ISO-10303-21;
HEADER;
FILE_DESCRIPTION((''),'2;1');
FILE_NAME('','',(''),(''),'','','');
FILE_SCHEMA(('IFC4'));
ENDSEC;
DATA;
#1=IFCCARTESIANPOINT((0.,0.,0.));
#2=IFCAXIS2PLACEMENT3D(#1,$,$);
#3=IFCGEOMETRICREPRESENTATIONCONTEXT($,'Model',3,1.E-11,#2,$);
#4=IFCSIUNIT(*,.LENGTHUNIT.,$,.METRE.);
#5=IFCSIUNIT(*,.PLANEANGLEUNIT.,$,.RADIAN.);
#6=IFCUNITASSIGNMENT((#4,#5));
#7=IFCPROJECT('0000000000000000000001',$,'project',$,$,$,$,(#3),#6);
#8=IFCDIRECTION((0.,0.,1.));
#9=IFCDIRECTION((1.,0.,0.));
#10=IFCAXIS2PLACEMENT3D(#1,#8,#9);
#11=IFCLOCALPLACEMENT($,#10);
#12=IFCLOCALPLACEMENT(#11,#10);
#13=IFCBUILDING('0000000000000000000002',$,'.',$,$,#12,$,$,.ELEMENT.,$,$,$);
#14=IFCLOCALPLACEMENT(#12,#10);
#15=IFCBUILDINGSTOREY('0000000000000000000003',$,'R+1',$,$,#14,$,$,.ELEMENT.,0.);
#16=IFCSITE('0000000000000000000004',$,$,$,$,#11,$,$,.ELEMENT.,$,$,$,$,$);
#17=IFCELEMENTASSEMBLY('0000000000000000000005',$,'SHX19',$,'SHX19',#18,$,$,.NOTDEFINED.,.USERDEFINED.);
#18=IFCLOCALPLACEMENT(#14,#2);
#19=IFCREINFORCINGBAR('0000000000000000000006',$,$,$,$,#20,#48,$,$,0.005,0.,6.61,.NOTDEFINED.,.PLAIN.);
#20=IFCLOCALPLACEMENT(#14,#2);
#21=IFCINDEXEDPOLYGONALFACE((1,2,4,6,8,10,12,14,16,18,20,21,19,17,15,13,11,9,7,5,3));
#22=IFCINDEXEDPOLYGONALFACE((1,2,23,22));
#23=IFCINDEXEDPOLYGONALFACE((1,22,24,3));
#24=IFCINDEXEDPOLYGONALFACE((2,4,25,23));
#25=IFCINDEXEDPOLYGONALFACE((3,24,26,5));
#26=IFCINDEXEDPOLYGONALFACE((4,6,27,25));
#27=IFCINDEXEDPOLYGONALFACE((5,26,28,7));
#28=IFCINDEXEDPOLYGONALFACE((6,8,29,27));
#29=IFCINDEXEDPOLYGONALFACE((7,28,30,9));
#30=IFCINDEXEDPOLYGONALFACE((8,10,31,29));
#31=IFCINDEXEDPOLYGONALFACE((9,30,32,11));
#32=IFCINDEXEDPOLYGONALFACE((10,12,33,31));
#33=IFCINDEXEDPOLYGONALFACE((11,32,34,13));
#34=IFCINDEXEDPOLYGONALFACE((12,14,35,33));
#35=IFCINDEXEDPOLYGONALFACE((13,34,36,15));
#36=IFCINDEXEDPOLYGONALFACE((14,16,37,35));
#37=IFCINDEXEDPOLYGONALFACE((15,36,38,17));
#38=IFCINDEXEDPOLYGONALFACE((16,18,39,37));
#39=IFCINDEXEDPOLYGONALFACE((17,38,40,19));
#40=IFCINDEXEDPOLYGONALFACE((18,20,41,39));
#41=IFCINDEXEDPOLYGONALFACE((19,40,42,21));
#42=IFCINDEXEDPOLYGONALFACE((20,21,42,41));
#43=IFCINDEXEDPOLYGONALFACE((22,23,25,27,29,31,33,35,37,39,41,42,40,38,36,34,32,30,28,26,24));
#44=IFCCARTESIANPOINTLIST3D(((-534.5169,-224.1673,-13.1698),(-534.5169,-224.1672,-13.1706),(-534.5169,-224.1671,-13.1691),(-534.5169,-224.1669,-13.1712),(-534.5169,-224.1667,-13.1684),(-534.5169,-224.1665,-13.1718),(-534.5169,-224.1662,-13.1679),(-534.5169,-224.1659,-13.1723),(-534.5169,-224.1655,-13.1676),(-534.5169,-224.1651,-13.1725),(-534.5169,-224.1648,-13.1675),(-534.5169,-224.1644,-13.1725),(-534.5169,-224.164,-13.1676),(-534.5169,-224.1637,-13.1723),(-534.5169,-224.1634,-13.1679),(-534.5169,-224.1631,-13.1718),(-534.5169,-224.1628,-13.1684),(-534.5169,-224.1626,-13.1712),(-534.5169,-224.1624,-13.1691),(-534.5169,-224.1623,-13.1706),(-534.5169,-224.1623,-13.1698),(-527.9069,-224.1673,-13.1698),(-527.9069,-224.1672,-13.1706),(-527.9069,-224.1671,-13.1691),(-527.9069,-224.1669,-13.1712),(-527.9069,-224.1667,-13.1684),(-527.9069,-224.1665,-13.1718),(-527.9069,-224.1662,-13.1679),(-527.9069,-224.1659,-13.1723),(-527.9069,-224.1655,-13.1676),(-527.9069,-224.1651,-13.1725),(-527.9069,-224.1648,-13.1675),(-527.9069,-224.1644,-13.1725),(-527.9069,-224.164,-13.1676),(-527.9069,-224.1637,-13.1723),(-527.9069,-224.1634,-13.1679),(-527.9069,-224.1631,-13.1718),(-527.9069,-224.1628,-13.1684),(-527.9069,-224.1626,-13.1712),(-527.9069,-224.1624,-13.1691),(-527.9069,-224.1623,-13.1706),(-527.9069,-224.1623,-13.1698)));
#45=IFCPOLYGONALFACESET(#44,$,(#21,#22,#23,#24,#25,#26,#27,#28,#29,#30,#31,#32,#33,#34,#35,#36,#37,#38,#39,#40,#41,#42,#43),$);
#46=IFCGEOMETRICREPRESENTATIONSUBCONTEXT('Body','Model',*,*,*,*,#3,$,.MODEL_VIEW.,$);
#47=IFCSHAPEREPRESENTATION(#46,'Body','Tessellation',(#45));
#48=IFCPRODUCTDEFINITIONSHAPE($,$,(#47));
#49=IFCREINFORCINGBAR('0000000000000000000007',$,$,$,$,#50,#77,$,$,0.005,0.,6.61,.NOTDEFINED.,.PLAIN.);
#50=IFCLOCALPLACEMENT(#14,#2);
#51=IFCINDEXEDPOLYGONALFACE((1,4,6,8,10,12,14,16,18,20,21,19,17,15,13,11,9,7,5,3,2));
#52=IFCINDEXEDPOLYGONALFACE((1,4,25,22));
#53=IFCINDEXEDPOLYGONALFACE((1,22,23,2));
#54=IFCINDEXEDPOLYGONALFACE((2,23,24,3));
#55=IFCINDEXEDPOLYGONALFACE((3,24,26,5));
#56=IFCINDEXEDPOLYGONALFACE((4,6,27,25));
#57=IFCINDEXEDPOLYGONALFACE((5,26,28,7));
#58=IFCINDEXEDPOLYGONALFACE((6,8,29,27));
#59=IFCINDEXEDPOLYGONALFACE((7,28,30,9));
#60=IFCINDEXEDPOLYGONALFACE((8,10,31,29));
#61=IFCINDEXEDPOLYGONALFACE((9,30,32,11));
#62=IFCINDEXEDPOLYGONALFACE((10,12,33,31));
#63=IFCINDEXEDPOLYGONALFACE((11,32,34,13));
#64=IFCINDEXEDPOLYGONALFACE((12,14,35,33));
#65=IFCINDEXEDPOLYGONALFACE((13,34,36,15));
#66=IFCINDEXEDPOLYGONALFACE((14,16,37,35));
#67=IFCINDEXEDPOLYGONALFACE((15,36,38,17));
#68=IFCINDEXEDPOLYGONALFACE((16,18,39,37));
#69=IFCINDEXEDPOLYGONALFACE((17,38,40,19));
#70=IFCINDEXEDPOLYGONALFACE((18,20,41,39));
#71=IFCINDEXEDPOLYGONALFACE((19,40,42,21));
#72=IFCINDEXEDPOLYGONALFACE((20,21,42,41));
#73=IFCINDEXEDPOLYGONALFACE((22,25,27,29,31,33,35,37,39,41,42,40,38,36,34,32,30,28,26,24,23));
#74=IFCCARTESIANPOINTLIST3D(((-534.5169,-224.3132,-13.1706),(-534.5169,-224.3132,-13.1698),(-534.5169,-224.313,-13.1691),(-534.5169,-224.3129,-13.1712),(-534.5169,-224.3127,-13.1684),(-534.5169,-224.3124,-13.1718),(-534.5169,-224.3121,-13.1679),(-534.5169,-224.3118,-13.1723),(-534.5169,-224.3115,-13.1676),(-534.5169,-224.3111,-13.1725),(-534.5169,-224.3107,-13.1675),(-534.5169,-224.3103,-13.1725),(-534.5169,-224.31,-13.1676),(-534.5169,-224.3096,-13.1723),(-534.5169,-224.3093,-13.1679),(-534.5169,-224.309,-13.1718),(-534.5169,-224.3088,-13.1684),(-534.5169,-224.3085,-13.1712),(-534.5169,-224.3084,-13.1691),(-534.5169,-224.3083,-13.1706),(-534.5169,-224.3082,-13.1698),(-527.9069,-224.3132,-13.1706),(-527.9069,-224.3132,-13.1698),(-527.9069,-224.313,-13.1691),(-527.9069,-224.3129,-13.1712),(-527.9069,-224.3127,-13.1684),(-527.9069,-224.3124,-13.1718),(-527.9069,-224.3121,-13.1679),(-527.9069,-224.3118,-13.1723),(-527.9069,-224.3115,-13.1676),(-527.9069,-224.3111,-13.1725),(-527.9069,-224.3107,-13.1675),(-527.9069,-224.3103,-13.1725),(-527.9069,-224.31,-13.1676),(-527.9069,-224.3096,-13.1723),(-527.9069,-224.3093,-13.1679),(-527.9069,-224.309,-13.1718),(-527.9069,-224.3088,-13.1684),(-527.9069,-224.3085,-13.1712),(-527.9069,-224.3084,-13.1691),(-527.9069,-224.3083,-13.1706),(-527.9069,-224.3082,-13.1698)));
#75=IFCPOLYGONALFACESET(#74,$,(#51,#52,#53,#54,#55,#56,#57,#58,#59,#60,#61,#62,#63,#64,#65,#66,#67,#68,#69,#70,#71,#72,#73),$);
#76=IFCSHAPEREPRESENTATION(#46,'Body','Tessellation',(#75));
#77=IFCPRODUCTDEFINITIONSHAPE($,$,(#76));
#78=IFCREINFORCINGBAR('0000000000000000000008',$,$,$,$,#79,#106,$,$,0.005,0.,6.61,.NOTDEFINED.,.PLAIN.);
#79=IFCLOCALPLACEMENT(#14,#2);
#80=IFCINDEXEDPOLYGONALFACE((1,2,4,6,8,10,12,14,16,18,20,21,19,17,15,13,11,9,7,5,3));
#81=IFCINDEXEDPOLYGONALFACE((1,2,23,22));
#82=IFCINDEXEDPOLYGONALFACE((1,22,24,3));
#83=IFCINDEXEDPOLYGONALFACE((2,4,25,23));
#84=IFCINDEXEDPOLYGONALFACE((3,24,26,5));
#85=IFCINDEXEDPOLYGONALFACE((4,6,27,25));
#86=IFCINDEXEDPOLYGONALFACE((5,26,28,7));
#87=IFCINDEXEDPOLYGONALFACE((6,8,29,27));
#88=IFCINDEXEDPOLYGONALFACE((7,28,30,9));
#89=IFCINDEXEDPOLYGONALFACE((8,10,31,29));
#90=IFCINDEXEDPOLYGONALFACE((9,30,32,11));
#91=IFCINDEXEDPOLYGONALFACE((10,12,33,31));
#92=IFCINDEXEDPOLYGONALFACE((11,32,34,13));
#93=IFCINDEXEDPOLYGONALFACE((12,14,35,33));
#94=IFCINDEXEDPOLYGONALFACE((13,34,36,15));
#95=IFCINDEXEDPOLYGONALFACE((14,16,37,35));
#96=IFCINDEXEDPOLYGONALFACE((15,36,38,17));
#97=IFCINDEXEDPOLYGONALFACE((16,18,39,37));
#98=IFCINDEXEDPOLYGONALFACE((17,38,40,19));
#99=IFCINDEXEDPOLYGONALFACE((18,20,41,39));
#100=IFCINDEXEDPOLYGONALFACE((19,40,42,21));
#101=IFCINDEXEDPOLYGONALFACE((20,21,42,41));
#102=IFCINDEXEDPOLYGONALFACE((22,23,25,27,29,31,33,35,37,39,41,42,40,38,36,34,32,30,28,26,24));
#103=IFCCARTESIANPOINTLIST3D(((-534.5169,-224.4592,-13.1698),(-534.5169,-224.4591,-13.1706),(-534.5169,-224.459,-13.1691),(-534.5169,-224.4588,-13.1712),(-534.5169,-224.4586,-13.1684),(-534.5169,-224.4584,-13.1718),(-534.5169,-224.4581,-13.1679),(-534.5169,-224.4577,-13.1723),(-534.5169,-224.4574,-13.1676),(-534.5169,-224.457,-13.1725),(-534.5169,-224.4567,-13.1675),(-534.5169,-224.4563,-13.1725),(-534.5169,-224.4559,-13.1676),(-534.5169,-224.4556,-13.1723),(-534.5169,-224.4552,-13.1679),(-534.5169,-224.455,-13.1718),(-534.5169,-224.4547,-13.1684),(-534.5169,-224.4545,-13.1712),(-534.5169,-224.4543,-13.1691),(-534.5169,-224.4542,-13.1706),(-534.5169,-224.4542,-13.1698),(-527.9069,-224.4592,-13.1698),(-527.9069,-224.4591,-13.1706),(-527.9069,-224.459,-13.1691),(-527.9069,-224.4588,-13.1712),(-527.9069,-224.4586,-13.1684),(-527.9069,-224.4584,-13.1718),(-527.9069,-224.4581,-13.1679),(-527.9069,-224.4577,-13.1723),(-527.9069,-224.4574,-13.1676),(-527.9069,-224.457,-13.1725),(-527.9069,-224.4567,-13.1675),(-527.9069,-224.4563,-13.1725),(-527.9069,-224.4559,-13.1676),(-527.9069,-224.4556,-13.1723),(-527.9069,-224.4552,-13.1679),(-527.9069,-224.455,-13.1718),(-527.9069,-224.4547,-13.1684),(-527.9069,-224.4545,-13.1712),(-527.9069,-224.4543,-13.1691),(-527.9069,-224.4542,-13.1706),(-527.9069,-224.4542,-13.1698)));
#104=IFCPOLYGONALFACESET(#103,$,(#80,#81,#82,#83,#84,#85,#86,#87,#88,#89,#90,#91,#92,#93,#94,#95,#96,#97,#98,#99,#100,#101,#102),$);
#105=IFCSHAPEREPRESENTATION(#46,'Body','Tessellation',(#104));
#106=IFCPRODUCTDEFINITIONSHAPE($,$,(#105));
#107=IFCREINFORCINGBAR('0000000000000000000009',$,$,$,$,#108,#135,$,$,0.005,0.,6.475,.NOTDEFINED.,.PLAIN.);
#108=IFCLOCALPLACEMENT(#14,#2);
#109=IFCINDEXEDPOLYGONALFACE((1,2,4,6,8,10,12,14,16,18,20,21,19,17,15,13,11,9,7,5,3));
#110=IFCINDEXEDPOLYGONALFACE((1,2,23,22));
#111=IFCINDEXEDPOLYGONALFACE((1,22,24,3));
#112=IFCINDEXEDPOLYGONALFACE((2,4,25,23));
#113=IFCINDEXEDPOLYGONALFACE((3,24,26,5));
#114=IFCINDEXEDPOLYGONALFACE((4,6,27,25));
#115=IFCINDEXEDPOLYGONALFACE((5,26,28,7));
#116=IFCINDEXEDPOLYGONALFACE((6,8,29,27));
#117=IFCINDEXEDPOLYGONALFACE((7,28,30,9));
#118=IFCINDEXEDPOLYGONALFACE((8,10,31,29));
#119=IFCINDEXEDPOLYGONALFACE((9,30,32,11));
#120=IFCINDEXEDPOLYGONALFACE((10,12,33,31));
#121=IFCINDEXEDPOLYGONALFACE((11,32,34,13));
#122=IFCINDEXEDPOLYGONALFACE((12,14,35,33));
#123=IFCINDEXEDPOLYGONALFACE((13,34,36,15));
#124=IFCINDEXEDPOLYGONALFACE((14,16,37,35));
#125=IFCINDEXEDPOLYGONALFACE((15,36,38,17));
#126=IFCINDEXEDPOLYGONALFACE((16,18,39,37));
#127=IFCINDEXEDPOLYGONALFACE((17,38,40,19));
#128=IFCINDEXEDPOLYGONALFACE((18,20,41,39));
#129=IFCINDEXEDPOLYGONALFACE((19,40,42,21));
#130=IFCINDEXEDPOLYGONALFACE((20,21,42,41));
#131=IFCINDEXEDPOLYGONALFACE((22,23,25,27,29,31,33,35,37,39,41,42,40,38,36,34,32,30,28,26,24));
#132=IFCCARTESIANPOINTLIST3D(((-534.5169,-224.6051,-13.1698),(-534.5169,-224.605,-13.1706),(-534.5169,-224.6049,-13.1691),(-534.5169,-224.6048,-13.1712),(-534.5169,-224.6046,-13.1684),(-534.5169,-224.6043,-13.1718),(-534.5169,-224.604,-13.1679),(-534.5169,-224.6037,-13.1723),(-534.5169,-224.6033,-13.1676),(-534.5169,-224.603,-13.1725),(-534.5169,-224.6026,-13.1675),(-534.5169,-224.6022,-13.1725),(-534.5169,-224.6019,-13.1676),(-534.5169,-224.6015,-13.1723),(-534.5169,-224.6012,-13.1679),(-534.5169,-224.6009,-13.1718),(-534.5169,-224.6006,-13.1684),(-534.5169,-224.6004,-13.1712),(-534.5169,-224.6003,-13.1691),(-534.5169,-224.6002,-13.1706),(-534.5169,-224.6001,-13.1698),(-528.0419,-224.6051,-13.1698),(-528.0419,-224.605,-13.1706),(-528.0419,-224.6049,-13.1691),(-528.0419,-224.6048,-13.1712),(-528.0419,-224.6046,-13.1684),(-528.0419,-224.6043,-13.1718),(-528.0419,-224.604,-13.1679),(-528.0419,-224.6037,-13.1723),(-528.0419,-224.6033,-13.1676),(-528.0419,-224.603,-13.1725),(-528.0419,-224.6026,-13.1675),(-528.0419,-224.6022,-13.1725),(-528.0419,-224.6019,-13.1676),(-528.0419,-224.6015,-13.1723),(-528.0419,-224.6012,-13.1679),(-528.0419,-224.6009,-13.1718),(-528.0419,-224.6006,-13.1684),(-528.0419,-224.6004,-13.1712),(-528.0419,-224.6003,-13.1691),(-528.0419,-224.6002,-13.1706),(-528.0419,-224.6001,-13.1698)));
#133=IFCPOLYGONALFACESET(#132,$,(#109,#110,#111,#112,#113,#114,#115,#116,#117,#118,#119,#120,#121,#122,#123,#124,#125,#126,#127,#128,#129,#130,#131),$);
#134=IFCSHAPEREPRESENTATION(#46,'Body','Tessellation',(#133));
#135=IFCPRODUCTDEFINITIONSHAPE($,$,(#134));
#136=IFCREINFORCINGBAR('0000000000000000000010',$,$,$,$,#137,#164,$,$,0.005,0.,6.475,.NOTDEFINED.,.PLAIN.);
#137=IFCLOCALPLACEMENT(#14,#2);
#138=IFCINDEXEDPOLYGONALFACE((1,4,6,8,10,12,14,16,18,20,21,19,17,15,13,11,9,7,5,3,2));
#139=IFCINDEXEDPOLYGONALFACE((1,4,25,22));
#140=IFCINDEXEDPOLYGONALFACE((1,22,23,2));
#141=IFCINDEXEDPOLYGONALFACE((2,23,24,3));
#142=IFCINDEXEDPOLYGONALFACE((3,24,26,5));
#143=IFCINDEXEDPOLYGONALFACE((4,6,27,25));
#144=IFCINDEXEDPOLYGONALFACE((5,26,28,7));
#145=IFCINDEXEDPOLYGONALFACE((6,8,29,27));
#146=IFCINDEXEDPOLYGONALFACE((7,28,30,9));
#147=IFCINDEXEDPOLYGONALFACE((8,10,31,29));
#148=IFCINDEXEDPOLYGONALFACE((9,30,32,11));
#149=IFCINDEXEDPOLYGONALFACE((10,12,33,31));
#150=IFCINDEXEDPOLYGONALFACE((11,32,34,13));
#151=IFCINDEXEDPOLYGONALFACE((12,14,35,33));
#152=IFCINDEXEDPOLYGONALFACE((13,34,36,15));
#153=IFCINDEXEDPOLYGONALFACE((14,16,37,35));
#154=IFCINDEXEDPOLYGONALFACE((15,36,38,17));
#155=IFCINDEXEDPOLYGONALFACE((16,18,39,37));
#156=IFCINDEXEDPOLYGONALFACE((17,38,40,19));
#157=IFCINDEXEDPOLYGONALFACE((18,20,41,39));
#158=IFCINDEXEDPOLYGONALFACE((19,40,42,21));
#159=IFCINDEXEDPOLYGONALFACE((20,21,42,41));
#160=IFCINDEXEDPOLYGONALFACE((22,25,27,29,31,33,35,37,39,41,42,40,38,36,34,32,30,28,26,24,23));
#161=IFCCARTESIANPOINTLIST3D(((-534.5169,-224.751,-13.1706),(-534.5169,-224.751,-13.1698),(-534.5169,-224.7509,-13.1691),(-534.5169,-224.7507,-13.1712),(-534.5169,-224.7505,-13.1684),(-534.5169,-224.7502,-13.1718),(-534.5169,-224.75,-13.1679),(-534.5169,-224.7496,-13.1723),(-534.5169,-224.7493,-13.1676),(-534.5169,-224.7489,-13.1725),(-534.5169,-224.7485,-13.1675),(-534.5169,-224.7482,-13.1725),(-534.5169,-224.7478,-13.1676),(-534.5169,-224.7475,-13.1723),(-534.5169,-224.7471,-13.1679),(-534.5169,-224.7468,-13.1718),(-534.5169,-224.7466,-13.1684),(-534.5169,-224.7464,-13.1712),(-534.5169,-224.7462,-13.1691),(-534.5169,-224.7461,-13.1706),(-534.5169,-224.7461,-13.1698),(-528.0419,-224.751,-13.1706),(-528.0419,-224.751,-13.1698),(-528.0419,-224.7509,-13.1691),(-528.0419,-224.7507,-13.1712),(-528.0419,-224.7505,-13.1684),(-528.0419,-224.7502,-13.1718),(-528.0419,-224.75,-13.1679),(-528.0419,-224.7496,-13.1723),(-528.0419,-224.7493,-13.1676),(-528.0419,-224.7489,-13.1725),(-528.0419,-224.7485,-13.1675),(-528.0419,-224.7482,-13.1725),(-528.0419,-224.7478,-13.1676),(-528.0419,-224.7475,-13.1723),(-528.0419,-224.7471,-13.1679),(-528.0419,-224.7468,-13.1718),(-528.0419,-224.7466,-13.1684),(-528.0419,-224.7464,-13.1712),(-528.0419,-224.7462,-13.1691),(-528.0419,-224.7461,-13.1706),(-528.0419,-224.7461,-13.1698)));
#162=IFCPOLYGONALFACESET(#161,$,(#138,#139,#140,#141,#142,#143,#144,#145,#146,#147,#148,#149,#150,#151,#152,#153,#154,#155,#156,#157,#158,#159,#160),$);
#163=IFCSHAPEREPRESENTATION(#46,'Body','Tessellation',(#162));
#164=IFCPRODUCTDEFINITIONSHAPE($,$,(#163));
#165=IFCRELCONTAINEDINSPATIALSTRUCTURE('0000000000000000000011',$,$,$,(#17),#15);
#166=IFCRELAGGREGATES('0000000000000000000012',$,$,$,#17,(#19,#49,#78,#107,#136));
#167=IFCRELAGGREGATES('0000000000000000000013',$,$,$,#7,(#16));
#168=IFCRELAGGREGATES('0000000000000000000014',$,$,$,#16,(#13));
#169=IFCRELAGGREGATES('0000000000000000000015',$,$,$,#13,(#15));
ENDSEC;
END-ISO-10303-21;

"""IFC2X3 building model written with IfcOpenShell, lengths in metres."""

from ifc_helpers import new_model, entity, si_unit, origin, origin_with_axes, place, context, subcontext, project, spatial, shape, element, aggregate, save


model = new_model("IFC2X3")

# Units and contexts
model_context = context("Model", 3, precision=1e-11, world=origin())
body_context = subcontext(model_context, "Body", "Model", "MODEL_VIEW")
ifc_project = project(units=[si_unit("LENGTHUNIT", "METRE"), si_unit("PLANEANGLEUNIT", "RADIAN")], contexts=[model_context])

# Site, building, storey
site_placement = place(None, origin_with_axes())
site = spatial("IfcSite", under=ifc_project, at=site_placement, CompositionType="ELEMENT")
building_placement = place(site_placement, origin_with_axes())
building = spatial("IfcBuilding", under=site, at=building_placement, Name=".", CompositionType="ELEMENT")
storey_placement = place(building_placement, origin_with_axes())
storey = spatial("IfcBuildingStorey", under=building, at=storey_placement, Name="R+1", CompositionType="ELEMENT", Elevation=0.0)

# Element assembly, reinforcing bars
assembly_1_placement = place(storey_placement, origin_with_axes())
assembly_1 = element("IfcElementAssembly", 1, at=assembly_1_placement, inside=storey, Name="SHX19", ObjectType="SHX19", AssemblyPlace="NOTDEFINED", PredefinedType="USERDEFINED")
reinforcing_bar_1_placement = place(assembly_1_placement, origin_with_axes())
reinforcing_bar_1 = element("IfcReinforcingBar", 2, at=reinforcing_bar_1_placement, BarLength=6.61, BarRole="NOTDEFINED", BarSurface="PLAIN", CrossSectionArea=0.0, NominalDiameter=0.005, shapes=[
    shape(body_context, "Body", "AdvancedSweptSolid", [entity("IfcSweptDiskSolid", entity("IfcPolyline", [entity("IfcCartesianPoint", [527.9069, 224.1648, 13.17]), entity("IfcCartesianPoint", [534.5169, 224.1648, 13.17])]), 0.0025, None, 0.0, 6.61)]),
    shape(body_context, "Body", "AdvancedSweptSolid", [entity("IfcSweptDiskSolid", entity("IfcPolyline", [entity("IfcCartesianPoint", [527.9069, 224.1648, 13.17]), entity("IfcCartesianPoint", [534.5169, 224.1648, 13.17])]), 0.0025, None, 0.0, 6.61)]),
])
reinforcing_bar_2_placement = place(assembly_1_placement, origin_with_axes())
reinforcing_bar_2 = element("IfcReinforcingBar", 3, at=reinforcing_bar_2_placement, BarLength=6.61, BarRole="NOTDEFINED", BarSurface="PLAIN", CrossSectionArea=0.0, NominalDiameter=0.005, shapes=[
    shape(body_context, "Body", "AdvancedSweptSolid", [entity("IfcSweptDiskSolid", entity("IfcPolyline", [entity("IfcCartesianPoint", [527.9069, 224.3107, 13.17]), entity("IfcCartesianPoint", [534.5169, 224.3107, 13.17])]), 0.0025, None, 0.0, 6.61)]),
    shape(body_context, "Body", "AdvancedSweptSolid", [entity("IfcSweptDiskSolid", entity("IfcPolyline", [entity("IfcCartesianPoint", [527.9069, 224.3107, 13.17]), entity("IfcCartesianPoint", [534.5169, 224.3107, 13.17])]), 0.0025, None, 0.0, 6.61)]),
])
reinforcing_bar_3_placement = place(assembly_1_placement, origin_with_axes())
reinforcing_bar_3 = element("IfcReinforcingBar", 4, at=reinforcing_bar_3_placement, BarLength=6.61, BarRole="NOTDEFINED", BarSurface="PLAIN", CrossSectionArea=0.0, NominalDiameter=0.005, shapes=[
    shape(body_context, "Body", "AdvancedSweptSolid", [entity("IfcSweptDiskSolid", entity("IfcPolyline", [entity("IfcCartesianPoint", [527.9069, 224.4567, 13.17]), entity("IfcCartesianPoint", [534.5169, 224.4567, 13.17])]), 0.0025, None, 0.0, 6.61)]),
    shape(body_context, "Body", "AdvancedSweptSolid", [entity("IfcSweptDiskSolid", entity("IfcPolyline", [entity("IfcCartesianPoint", [527.9069, 224.4567, 13.17]), entity("IfcCartesianPoint", [534.5169, 224.4567, 13.17])]), 0.0025, None, 0.0, 6.61)]),
])
reinforcing_bar_4_placement = place(assembly_1_placement, origin_with_axes())
reinforcing_bar_4 = element("IfcReinforcingBar", 5, at=reinforcing_bar_4_placement, BarLength=6.475, BarRole="NOTDEFINED", BarSurface="PLAIN", CrossSectionArea=0.0, NominalDiameter=0.005, shapes=[
    shape(body_context, "Body", "AdvancedSweptSolid", [entity("IfcSweptDiskSolid", entity("IfcPolyline", [entity("IfcCartesianPoint", [528.0419, 224.6026, 13.17]), entity("IfcCartesianPoint", [534.5169, 224.6026, 13.17])]), 0.0025, None, 0.0, 6.475)]),
    shape(body_context, "Body", "AdvancedSweptSolid", [entity("IfcSweptDiskSolid", entity("IfcPolyline", [entity("IfcCartesianPoint", [528.0419, 224.6026, 13.17]), entity("IfcCartesianPoint", [534.5169, 224.6026, 13.17])]), 0.0025, None, 0.0, 6.475)]),
])
reinforcing_bar_5_placement = place(assembly_1_placement, origin_with_axes())
reinforcing_bar_5 = element("IfcReinforcingBar", 6, at=reinforcing_bar_5_placement, BarLength=6.475, BarRole="NOTDEFINED", BarSurface="PLAIN", CrossSectionArea=0.0, NominalDiameter=0.005, shapes=[
    shape(body_context, "Body", "AdvancedSweptSolid", [entity("IfcSweptDiskSolid", entity("IfcPolyline", [entity("IfcCartesianPoint", [528.0419, 224.7485, 13.17]), entity("IfcCartesianPoint", [534.5169, 224.7485, 13.17])]), 0.0025, None, 0.0, 6.475)]),
    shape(body_context, "Body", "AdvancedSweptSolid", [entity("IfcSweptDiskSolid", entity("IfcPolyline", [entity("IfcCartesianPoint", [528.0419, 224.7485, 13.17]), entity("IfcCartesianPoint", [534.5169, 224.7485, 13.17])]), 0.0025, None, 0.0, 6.475)]),
])
aggregate(assembly_1, [reinforcing_bar_1, reinforcing_bar_2, reinforcing_bar_3, reinforcing_bar_4, reinforcing_bar_5])

save(model, "model.ifc")
